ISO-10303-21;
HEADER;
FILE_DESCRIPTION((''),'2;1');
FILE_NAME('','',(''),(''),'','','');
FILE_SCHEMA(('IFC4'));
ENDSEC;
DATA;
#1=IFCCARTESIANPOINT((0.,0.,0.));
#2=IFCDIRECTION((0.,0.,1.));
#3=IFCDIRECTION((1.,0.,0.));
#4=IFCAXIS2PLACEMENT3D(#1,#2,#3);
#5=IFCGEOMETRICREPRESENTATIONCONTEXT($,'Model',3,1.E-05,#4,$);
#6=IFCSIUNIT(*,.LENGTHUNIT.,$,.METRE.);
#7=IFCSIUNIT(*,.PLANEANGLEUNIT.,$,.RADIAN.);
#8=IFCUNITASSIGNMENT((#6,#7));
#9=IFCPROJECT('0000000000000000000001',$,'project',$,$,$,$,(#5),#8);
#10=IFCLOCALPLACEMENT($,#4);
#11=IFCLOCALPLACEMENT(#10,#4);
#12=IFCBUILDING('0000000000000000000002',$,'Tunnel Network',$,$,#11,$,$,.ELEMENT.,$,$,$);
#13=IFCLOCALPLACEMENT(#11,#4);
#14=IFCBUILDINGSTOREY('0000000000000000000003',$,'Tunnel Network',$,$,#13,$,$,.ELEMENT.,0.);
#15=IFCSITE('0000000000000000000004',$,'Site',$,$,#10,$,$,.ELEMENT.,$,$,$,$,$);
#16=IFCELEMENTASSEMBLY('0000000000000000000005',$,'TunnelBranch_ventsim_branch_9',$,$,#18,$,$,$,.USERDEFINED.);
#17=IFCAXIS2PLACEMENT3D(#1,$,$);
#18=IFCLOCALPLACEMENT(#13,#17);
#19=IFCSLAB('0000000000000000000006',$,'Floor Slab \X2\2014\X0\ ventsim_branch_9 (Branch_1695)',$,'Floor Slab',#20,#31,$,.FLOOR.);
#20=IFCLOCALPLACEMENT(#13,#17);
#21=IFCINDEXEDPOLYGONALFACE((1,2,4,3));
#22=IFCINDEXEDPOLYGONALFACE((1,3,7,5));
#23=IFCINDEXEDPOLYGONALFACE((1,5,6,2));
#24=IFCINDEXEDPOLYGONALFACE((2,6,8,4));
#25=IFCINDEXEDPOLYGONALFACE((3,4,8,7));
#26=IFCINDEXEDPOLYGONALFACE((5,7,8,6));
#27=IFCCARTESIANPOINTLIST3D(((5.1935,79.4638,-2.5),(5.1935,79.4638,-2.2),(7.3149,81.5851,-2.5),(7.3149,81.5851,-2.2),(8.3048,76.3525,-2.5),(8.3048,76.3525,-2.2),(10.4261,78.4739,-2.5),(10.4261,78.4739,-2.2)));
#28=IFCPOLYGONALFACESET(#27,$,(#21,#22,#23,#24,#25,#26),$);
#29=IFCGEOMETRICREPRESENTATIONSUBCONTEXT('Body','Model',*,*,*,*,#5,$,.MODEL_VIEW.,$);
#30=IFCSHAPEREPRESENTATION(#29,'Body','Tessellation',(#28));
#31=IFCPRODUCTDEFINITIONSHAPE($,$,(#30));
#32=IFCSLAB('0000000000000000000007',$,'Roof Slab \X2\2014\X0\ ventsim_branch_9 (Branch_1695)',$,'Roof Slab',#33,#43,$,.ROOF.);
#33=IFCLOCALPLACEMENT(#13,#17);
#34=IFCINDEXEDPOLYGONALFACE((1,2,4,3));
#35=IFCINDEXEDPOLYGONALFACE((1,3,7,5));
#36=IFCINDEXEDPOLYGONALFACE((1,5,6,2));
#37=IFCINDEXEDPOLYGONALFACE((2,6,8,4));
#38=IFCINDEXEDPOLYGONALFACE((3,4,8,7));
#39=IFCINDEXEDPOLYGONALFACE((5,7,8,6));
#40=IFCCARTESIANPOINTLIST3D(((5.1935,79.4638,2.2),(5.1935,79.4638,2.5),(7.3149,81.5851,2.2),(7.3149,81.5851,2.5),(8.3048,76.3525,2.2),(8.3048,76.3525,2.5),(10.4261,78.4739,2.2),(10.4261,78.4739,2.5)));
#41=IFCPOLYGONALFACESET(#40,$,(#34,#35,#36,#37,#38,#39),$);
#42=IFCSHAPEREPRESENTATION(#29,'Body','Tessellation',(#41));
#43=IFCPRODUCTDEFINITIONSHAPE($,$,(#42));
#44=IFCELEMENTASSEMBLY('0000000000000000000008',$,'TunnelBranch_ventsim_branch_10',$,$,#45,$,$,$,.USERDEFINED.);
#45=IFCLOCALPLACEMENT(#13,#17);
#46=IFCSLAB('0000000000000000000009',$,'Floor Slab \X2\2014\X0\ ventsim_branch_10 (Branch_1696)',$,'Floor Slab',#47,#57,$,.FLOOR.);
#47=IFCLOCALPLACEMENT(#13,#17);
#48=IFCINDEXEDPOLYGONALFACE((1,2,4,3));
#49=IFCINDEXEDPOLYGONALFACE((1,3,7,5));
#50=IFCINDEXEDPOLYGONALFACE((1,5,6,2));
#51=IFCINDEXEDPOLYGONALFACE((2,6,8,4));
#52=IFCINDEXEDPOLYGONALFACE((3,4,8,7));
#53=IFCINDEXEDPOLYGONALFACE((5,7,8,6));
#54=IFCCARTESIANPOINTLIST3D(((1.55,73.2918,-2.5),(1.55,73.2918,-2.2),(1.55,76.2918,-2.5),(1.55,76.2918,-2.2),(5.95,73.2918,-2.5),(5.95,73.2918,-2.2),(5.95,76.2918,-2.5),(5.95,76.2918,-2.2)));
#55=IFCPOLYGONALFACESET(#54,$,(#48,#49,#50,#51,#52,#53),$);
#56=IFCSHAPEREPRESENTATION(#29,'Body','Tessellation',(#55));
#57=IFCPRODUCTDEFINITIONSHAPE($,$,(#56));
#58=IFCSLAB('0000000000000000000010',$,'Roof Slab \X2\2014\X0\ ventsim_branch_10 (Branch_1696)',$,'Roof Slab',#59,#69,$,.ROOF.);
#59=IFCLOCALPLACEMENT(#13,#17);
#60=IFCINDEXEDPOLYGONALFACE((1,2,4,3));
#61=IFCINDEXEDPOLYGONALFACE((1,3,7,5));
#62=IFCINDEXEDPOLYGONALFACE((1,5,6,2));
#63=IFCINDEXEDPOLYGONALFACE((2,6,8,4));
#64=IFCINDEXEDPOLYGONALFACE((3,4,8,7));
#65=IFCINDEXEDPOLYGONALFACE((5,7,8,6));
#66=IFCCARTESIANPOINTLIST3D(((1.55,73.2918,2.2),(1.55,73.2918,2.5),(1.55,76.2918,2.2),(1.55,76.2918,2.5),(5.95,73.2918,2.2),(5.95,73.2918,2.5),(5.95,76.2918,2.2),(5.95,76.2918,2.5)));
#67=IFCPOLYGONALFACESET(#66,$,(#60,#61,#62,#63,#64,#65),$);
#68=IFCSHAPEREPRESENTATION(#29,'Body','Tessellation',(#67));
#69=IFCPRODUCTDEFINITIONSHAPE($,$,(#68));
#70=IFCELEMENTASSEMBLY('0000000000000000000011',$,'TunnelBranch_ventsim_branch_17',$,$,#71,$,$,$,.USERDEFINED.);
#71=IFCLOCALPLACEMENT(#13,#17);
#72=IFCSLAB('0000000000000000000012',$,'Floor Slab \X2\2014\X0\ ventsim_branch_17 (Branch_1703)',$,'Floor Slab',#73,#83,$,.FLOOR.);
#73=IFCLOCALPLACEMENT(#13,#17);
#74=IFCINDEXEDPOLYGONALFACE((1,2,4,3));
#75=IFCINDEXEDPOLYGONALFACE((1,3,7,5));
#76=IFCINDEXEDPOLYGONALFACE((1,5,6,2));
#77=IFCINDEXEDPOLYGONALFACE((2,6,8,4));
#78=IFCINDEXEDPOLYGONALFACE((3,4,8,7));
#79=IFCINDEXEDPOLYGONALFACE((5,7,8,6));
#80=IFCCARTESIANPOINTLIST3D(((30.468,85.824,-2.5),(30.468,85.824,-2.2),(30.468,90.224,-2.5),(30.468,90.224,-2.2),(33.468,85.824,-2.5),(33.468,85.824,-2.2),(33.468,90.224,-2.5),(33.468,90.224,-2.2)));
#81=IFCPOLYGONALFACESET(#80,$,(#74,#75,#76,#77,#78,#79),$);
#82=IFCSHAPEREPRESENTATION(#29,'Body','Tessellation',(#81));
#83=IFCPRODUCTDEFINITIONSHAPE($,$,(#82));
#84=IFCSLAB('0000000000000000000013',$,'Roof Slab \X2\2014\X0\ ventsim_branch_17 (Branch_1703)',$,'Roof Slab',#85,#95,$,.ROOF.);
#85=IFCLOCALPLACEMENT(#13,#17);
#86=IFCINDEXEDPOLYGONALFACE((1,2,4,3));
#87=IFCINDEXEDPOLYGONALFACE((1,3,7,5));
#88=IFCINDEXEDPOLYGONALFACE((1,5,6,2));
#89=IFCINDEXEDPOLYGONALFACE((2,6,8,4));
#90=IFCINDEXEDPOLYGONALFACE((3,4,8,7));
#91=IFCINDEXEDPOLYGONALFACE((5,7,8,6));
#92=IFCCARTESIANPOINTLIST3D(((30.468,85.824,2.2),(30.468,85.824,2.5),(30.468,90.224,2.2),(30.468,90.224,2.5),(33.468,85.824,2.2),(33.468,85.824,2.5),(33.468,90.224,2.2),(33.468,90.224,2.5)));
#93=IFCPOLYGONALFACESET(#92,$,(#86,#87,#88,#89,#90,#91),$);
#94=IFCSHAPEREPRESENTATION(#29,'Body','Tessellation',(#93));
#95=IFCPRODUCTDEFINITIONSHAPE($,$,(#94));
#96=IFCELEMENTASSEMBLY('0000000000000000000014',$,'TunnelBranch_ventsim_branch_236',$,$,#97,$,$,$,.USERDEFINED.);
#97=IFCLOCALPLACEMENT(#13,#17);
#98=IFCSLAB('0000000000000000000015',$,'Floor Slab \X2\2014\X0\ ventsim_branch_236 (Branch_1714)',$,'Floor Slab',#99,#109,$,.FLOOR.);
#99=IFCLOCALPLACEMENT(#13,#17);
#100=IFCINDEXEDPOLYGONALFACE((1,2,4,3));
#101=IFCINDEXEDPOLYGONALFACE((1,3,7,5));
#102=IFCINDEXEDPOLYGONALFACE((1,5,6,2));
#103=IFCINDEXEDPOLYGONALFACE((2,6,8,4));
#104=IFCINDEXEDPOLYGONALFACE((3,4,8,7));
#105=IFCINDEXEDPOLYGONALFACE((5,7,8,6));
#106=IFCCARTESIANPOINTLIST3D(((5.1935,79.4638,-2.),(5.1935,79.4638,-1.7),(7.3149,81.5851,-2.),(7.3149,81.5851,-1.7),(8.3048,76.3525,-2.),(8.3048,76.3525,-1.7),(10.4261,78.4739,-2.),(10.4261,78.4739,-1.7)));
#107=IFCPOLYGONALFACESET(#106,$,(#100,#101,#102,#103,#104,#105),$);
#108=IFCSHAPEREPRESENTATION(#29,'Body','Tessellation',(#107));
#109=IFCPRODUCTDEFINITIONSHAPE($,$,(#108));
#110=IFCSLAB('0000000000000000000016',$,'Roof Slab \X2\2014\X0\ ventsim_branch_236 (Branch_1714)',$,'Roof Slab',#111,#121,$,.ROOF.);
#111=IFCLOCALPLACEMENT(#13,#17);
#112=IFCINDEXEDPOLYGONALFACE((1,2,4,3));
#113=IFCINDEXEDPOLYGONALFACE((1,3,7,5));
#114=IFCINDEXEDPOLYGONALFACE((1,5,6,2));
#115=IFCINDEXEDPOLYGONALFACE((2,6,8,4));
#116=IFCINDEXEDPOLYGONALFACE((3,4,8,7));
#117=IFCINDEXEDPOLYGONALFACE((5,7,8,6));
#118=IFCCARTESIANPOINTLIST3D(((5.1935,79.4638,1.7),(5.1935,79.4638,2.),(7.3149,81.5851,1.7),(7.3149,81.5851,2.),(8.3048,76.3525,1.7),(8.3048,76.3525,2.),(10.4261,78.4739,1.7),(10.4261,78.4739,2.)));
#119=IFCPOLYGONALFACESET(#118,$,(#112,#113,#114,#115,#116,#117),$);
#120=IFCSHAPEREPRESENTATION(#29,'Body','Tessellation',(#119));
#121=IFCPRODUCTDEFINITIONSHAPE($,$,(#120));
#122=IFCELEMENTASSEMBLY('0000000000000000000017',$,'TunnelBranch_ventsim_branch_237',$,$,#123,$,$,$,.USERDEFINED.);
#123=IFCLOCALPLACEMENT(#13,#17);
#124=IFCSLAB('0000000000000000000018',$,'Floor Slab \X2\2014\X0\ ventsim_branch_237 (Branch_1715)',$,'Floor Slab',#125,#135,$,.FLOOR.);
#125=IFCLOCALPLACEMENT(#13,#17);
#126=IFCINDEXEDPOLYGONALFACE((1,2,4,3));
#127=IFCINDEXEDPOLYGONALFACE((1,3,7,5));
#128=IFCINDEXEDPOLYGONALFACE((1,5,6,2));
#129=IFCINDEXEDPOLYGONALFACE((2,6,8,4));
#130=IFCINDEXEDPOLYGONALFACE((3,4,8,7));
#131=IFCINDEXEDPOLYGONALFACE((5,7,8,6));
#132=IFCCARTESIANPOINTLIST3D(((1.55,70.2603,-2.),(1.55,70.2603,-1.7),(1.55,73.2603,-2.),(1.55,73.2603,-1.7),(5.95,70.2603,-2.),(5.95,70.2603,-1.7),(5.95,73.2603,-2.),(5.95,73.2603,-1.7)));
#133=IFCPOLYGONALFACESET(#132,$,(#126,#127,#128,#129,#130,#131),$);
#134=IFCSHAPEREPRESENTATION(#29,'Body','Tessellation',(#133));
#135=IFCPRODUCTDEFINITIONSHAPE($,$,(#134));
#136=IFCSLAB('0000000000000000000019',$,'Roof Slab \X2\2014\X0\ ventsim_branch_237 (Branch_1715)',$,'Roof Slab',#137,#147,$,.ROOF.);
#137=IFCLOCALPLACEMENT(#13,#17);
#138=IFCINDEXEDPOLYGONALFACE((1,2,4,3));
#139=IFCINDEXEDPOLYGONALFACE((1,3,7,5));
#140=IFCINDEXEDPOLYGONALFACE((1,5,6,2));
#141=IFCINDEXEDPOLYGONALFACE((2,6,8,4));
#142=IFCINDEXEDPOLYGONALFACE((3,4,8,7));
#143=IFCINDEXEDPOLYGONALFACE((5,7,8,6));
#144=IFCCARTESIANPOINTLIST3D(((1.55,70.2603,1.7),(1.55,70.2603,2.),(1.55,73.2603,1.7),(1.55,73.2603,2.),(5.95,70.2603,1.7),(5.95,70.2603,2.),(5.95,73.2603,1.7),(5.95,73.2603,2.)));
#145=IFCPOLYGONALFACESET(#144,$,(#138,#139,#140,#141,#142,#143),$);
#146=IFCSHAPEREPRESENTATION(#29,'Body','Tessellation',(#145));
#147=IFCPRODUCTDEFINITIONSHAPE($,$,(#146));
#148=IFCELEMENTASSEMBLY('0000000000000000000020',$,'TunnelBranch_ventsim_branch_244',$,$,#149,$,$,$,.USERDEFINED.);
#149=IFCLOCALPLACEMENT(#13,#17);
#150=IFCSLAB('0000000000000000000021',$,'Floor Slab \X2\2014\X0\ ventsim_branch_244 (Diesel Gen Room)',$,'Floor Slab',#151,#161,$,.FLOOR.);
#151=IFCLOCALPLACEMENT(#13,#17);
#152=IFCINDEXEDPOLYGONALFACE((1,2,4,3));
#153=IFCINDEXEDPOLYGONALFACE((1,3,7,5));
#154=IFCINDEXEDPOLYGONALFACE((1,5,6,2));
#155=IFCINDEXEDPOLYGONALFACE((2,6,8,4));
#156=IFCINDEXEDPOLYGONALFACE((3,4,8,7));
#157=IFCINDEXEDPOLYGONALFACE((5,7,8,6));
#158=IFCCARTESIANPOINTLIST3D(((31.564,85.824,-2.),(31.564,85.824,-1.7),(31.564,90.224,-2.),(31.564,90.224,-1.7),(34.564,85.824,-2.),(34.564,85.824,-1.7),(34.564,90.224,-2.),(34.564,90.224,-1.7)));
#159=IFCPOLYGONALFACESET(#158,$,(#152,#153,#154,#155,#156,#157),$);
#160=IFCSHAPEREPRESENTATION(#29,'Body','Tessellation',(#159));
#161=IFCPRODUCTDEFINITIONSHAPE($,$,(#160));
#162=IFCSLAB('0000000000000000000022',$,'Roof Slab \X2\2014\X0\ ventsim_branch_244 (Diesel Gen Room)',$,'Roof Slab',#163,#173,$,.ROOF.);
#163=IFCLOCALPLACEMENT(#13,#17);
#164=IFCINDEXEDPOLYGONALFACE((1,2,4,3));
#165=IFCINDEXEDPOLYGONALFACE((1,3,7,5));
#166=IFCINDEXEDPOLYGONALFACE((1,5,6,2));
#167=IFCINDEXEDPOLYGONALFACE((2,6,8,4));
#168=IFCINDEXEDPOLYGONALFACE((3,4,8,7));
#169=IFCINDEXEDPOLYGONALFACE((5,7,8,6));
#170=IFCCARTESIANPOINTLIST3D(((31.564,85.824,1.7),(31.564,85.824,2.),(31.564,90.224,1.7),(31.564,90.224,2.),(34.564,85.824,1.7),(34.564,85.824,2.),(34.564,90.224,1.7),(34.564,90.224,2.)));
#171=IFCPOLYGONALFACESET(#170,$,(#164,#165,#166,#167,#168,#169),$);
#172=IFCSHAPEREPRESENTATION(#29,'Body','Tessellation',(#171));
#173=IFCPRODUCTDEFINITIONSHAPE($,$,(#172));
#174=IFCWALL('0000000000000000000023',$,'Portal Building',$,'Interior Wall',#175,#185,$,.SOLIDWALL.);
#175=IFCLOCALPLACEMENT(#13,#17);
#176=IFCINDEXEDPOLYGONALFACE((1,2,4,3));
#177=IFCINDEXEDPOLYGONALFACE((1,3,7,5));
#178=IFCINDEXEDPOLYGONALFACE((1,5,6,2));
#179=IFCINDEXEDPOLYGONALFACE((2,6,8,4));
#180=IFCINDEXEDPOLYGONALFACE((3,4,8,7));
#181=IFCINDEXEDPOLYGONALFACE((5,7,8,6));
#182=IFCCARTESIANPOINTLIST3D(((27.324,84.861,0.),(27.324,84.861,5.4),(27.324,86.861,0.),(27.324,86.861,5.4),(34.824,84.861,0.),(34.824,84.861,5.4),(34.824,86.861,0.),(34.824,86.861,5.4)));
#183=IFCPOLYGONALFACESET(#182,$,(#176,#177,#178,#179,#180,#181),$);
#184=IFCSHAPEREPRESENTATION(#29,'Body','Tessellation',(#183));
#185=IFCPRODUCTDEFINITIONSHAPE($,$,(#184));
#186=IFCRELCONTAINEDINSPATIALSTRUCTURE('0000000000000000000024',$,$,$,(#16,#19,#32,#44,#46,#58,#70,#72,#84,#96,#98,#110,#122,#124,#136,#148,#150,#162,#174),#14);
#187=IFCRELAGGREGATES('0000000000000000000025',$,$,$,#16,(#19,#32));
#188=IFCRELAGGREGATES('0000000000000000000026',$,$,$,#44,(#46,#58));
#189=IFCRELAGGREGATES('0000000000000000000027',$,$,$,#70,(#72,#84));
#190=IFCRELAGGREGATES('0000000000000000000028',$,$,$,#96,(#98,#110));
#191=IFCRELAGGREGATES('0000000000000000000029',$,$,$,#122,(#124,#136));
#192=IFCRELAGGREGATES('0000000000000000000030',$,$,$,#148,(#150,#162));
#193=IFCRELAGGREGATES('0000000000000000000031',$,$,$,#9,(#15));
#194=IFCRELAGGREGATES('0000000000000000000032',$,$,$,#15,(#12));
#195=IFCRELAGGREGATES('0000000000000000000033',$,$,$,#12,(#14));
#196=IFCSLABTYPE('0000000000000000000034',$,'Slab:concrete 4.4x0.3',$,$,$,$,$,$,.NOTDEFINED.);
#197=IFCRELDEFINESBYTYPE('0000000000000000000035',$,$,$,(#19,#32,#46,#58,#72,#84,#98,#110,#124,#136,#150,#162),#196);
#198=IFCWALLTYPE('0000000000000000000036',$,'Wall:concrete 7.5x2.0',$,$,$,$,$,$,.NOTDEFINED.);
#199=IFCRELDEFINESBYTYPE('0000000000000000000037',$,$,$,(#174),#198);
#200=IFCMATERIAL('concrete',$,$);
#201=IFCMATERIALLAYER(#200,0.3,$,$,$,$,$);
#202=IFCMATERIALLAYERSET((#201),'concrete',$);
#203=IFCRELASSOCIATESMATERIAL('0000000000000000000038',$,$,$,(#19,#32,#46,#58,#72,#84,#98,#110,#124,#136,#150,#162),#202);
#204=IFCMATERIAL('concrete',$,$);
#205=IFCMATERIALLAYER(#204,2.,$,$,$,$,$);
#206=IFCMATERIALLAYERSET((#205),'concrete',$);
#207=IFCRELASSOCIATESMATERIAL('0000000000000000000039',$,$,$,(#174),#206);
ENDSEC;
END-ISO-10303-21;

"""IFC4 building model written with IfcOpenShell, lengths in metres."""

from ifc_helpers import new_model, si_unit, frame, origin_with_axes, origin_2d_with_axis, place, context, subcontext, project, spatial, rectangle, extrude, material, layer, layer_set, layer_usage, type_object, element, aggregate, save


model = new_model("IFC4")

# Units and contexts
model_context = context("Model", 3, precision=1e-05, world=origin_with_axes())
body_context = subcontext(model_context, "Body", "Model", "MODEL_VIEW")
ifc_project = project(units=[si_unit("LENGTHUNIT", "METRE"), si_unit("PLANEANGLEUNIT", "RADIAN")], contexts=[model_context])

# Site, building, storey
site_placement = place(None, origin_with_axes())
site = spatial("IfcSite", under=ifc_project, at=site_placement, Name="Site", CompositionType="ELEMENT")
building_placement = place(site_placement, origin_with_axes())
building = spatial("IfcBuilding", under=site, at=building_placement, Name="Tunnel Network", CompositionType="ELEMENT")
storey_placement = place(building_placement, origin_with_axes())
storey = spatial("IfcBuildingStorey", under=building, at=storey_placement, Name="Tunnel Network", CompositionType="ELEMENT", Elevation=0.0)

# Element assemblies, slabs
assembly_1_placement = place(storey_placement, frame((10.5322, 78.3678, 0.0), z_axis=(-0.707107, -0.707106, 0.0), x_axis=(-0.707106, 0.707107, 0.0)))
assembly_1 = element("IfcElementAssembly", 1, at=assembly_1_placement, inside=storey, Name="TunnelBranch_ventsim_branch_9", PredefinedType="USERDEFINED")
ifc_material_1 = material(Name="concrete")
ifc_layer_1 = layer(ifc_material_1, 0.3)
ifc_layer_set_1 = layer_set([ifc_layer_1], Name="concrete")
ifc_layer_usage_1 = layer_usage(ifc_layer_set_1, "AXIS3", "POSITIVE", 0.0)
slab_type = type_object("IfcSlabType", Name="Slab:concrete 4.4x0.3")
slab_1_placement = place(storey_placement, frame((8.8705, 80.0295, -2.35), z_axis=(-0.707107, -0.707106, 0.0), x_axis=(-0.707106, 0.707107, 0.0)))
slab_1 = element("IfcSlab", 2, at=slab_1_placement, inside=storey, type_object=slab_type, material=ifc_layer_usage_1, Name="Floor Slab — ventsim_branch_9 (Branch_1695)", ObjectType="Floor Slab", PredefinedType="FLOOR", context=body_context, shape_type="SweptSolid", body=[
    extrude(rectangle(XDim=4.4, YDim=0.3, at=origin_2d_with_axis()), origin_with_axes(), (0.0, 0.0, 1.0), 3.0),
])
ifc_layer_usage_2 = layer_usage(ifc_layer_set_1, "AXIS3", "POSITIVE", 0.0)
slab_2_placement = place(storey_placement, frame((8.8705, 80.0295, 2.35), z_axis=(-0.707107, -0.707106, 0.0), x_axis=(-0.707106, 0.707107, 0.0)))
slab_2 = element("IfcSlab", 3, at=slab_2_placement, inside=storey, type_object=slab_type, material=ifc_layer_usage_2, Name="Roof Slab — ventsim_branch_9 (Branch_1695)", ObjectType="Roof Slab", PredefinedType="ROOF", context=body_context, shape_type="SweptSolid", body=[
    extrude(rectangle(XDim=4.4, YDim=0.3, at=origin_2d_with_axis()), origin_with_axes(), (0.0, 0.0, 1.0), 3.0),
])
assembly_2_placement = place(storey_placement, frame((6.1, 75.8132, 0.0), z_axis=(0.0, -1.0, 0.0), x_axis=(-1.0, 0.0, 0.0)))
assembly_2 = element("IfcElementAssembly", 4, at=assembly_2_placement, inside=storey, Name="TunnelBranch_ventsim_branch_10", PredefinedType="USERDEFINED")
ifc_layer_usage_3 = layer_usage(ifc_layer_set_1, "AXIS3", "POSITIVE", 0.0)
slab_3_placement = place(storey_placement, frame((3.75, 76.2918, -2.35), z_axis=(0.0, -1.0, 0.0), x_axis=(-1.0, 0.0, 0.0)))
slab_3 = element("IfcSlab", 5, at=slab_3_placement, inside=storey, type_object=slab_type, material=ifc_layer_usage_3, Name="Floor Slab — ventsim_branch_10 (Branch_1696)", ObjectType="Floor Slab", PredefinedType="FLOOR", context=body_context, shape_type="SweptSolid", body=[
    extrude(rectangle(XDim=4.4, YDim=0.3, at=origin_2d_with_axis()), origin_with_axes(), (0.0, 0.0, 1.0), 3.0),
])
ifc_layer_usage_4 = layer_usage(ifc_layer_set_1, "AXIS3", "POSITIVE", 0.0)
slab_4_placement = place(storey_placement, frame((3.75, 76.2918, 2.35), z_axis=(0.0, -1.0, 0.0), x_axis=(-1.0, 0.0, 0.0)))
slab_4 = element("IfcSlab", 6, at=slab_4_placement, inside=storey, type_object=slab_type, material=ifc_layer_usage_4, Name="Roof Slab — ventsim_branch_10 (Branch_1696)", ObjectType="Roof Slab", PredefinedType="ROOF", context=body_context, shape_type="SweptSolid", body=[
    extrude(rectangle(XDim=4.4, YDim=0.3, at=origin_2d_with_axis()), origin_with_axes(), (0.0, 0.0, 1.0), 3.0),
])
assembly_3_placement = place(storey_placement, frame((30.468, 90.374, 0.0), z_axis=(1.0, 0.0, 0.0), x_axis=(0.0, -1.0, 0.0)))
assembly_3 = element("IfcElementAssembly", 7, at=assembly_3_placement, inside=storey, Name="TunnelBranch_ventsim_branch_17", PredefinedType="USERDEFINED")
ifc_layer_usage_5 = layer_usage(ifc_layer_set_1, "AXIS3", "POSITIVE", 0.0)
slab_5_placement = place(storey_placement, frame((30.468, 88.024, -2.35), z_axis=(1.0, 0.0, 0.0), x_axis=(0.0, -1.0, 0.0)))
slab_5 = element("IfcSlab", 8, at=slab_5_placement, inside=storey, type_object=slab_type, material=ifc_layer_usage_5, Name="Floor Slab — ventsim_branch_17 (Branch_1703)", ObjectType="Floor Slab", PredefinedType="FLOOR", context=body_context, shape_type="SweptSolid", body=[
    extrude(rectangle(XDim=4.4, YDim=0.3, at=origin_2d_with_axis()), origin_with_axes(), (0.0, 0.0, 1.0), 3.0),
])
ifc_layer_usage_6 = layer_usage(ifc_layer_set_1, "AXIS3", "POSITIVE", 0.0)
slab_6_placement = place(storey_placement, frame((30.468, 88.024, 2.35), z_axis=(1.0, 0.0, 0.0), x_axis=(0.0, -1.0, 0.0)))
slab_6 = element("IfcSlab", 9, at=slab_6_placement, inside=storey, type_object=slab_type, material=ifc_layer_usage_6, Name="Roof Slab — ventsim_branch_17 (Branch_1703)", ObjectType="Roof Slab", PredefinedType="ROOF", context=body_context, shape_type="SweptSolid", body=[
    extrude(rectangle(XDim=4.4, YDim=0.3, at=origin_2d_with_axis()), origin_with_axes(), (0.0, 0.0, 1.0), 3.0),
])
assembly_4_placement = place(storey_placement, frame((10.5322, 78.3678, 0.0), z_axis=(-0.707107, -0.707106, 0.0), x_axis=(-0.707106, 0.707107, 0.0)))
assembly_4 = element("IfcElementAssembly", 10, at=assembly_4_placement, inside=storey, Name="TunnelBranch_ventsim_branch_236", PredefinedType="USERDEFINED")
ifc_layer_usage_7 = layer_usage(ifc_layer_set_1, "AXIS3", "POSITIVE", 0.0)
slab_7_placement = place(storey_placement, frame((8.8705, 80.0295, -1.85), z_axis=(-0.707107, -0.707106, 0.0), x_axis=(-0.707106, 0.707107, 0.0)))
slab_7 = element("IfcSlab", 11, at=slab_7_placement, inside=storey, type_object=slab_type, material=ifc_layer_usage_7, Name="Floor Slab — ventsim_branch_236 (Branch_1714)", ObjectType="Floor Slab", PredefinedType="FLOOR", context=body_context, shape_type="SweptSolid", body=[
    extrude(rectangle(XDim=4.4, YDim=0.3, at=origin_2d_with_axis()), origin_with_axes(), (0.0, 0.0, 1.0), 3.0),
])
ifc_layer_usage_8 = layer_usage(ifc_layer_set_1, "AXIS3", "POSITIVE", 0.0)
slab_8_placement = place(storey_placement, frame((8.8705, 80.0295, 1.85), z_axis=(-0.707107, -0.707106, 0.0), x_axis=(-0.707106, 0.707107, 0.0)))
slab_8 = element("IfcSlab", 12, at=slab_8_placement, inside=storey, type_object=slab_type, material=ifc_layer_usage_8, Name="Roof Slab — ventsim_branch_236 (Branch_1714)", ObjectType="Roof Slab", PredefinedType="ROOF", context=body_context, shape_type="SweptSolid", body=[
    extrude(rectangle(XDim=4.4, YDim=0.3, at=origin_2d_with_axis()), origin_with_axes(), (0.0, 0.0, 1.0), 3.0),
])
assembly_5_placement = place(storey_placement, frame((6.1, 72.8908, 0.0), z_axis=(0.0, -1.0, 0.0), x_axis=(-1.0, 0.0, 0.0)))
assembly_5 = element("IfcElementAssembly", 13, at=assembly_5_placement, inside=storey, Name="TunnelBranch_ventsim_branch_237", PredefinedType="USERDEFINED")
ifc_layer_usage_9 = layer_usage(ifc_layer_set_1, "AXIS3", "POSITIVE", 0.0)
slab_9_placement = place(storey_placement, frame((3.75, 73.2603, -1.85), z_axis=(0.0, -1.0, 0.0), x_axis=(-1.0, 0.0, 0.0)))
slab_9 = element("IfcSlab", 14, at=slab_9_placement, inside=storey, type_object=slab_type, material=ifc_layer_usage_9, Name="Floor Slab — ventsim_branch_237 (Branch_1715)", ObjectType="Floor Slab", PredefinedType="FLOOR", context=body_context, shape_type="SweptSolid", body=[
    extrude(rectangle(XDim=4.4, YDim=0.3, at=origin_2d_with_axis()), origin_with_axes(), (0.0, 0.0, 1.0), 3.0),
])
ifc_layer_usage_10 = layer_usage(ifc_layer_set_1, "AXIS3", "POSITIVE", 0.0)
slab_10_placement = place(storey_placement, frame((3.75, 73.2603, 1.85), z_axis=(0.0, -1.0, 0.0), x_axis=(-1.0, 0.0, 0.0)))
slab_10 = element("IfcSlab", 15, at=slab_10_placement, inside=storey, type_object=slab_type, material=ifc_layer_usage_10, Name="Roof Slab — ventsim_branch_237 (Branch_1715)", ObjectType="Roof Slab", PredefinedType="ROOF", context=body_context, shape_type="SweptSolid", body=[
    extrude(rectangle(XDim=4.4, YDim=0.3, at=origin_2d_with_axis()), origin_with_axes(), (0.0, 0.0, 1.0), 3.0),
])
assembly_6_placement = place(storey_placement, frame((31.564, 90.374, 0.0), z_axis=(1.0, 0.0, 0.0), x_axis=(0.0, -1.0, 0.0)))
assembly_6 = element("IfcElementAssembly", 16, at=assembly_6_placement, inside=storey, Name="TunnelBranch_ventsim_branch_244", PredefinedType="USERDEFINED")
ifc_layer_usage_11 = layer_usage(ifc_layer_set_1, "AXIS3", "POSITIVE", 0.0)
slab_11_placement = place(storey_placement, frame((31.564, 88.024, -1.85), z_axis=(1.0, 0.0, 0.0), x_axis=(0.0, -1.0, 0.0)))
slab_11 = element("IfcSlab", 17, at=slab_11_placement, inside=storey, type_object=slab_type, material=ifc_layer_usage_11, Name="Floor Slab — ventsim_branch_244 (Diesel Gen Room)", ObjectType="Floor Slab", PredefinedType="FLOOR", context=body_context, shape_type="SweptSolid", body=[
    extrude(rectangle(XDim=4.4, YDim=0.3, at=origin_2d_with_axis()), origin_with_axes(), (0.0, 0.0, 1.0), 3.0),
])
ifc_layer_usage_12 = layer_usage(ifc_layer_set_1, "AXIS3", "POSITIVE", 0.0)
slab_12_placement = place(storey_placement, frame((31.564, 88.024, 1.85), z_axis=(1.0, 0.0, 0.0), x_axis=(0.0, -1.0, 0.0)))
slab_12 = element("IfcSlab", 18, at=slab_12_placement, inside=storey, type_object=slab_type, material=ifc_layer_usage_12, Name="Roof Slab — ventsim_branch_244 (Diesel Gen Room)", ObjectType="Roof Slab", PredefinedType="ROOF", context=body_context, shape_type="SweptSolid", body=[
    extrude(rectangle(XDim=4.4, YDim=0.3, at=origin_2d_with_axis()), origin_with_axes(), (0.0, 0.0, 1.0), 3.0),
])

# Wall
ifc_material_2 = material(Name="concrete")
ifc_layer_2 = layer(ifc_material_2, 2.0)
ifc_layer_set_2 = layer_set([ifc_layer_2], Name="concrete")
ifc_layer_usage_13 = layer_usage(ifc_layer_set_2, "AXIS2", "POSITIVE", 0.0)
wall_type_1 = type_object("IfcWallType", Name="Wall:concrete 7.5x2.0")
wall_1_placement = place(storey_placement, frame((31.074, 85.861, 0.0), z_axis=(0.0, 0.0, 1.0), x_axis=(1.0, 0.0, 0.0)))
element("IfcWall", 19, at=wall_1_placement, inside=storey, type_object=wall_type_1, material=ifc_layer_usage_13, Name="Portal Building", ObjectType="Interior Wall", PredefinedType="SOLIDWALL", context=body_context, shape_type="SweptSolid", body=[
    extrude(rectangle(XDim=7.5, YDim=2.0, at=origin_2d_with_axis()), origin_with_axes(), (0.0, 0.0, 1.0), 5.4),
])
aggregate(assembly_1, [slab_1, slab_2])
aggregate(assembly_2, [slab_3, slab_4])

aggregate(assembly_3, [slab_5, slab_6])
aggregate(assembly_4, [slab_7, slab_8])
aggregate(assembly_5, [slab_9, slab_10])
aggregate(assembly_6, [slab_11, slab_12])

save(model, "model.ifc")
